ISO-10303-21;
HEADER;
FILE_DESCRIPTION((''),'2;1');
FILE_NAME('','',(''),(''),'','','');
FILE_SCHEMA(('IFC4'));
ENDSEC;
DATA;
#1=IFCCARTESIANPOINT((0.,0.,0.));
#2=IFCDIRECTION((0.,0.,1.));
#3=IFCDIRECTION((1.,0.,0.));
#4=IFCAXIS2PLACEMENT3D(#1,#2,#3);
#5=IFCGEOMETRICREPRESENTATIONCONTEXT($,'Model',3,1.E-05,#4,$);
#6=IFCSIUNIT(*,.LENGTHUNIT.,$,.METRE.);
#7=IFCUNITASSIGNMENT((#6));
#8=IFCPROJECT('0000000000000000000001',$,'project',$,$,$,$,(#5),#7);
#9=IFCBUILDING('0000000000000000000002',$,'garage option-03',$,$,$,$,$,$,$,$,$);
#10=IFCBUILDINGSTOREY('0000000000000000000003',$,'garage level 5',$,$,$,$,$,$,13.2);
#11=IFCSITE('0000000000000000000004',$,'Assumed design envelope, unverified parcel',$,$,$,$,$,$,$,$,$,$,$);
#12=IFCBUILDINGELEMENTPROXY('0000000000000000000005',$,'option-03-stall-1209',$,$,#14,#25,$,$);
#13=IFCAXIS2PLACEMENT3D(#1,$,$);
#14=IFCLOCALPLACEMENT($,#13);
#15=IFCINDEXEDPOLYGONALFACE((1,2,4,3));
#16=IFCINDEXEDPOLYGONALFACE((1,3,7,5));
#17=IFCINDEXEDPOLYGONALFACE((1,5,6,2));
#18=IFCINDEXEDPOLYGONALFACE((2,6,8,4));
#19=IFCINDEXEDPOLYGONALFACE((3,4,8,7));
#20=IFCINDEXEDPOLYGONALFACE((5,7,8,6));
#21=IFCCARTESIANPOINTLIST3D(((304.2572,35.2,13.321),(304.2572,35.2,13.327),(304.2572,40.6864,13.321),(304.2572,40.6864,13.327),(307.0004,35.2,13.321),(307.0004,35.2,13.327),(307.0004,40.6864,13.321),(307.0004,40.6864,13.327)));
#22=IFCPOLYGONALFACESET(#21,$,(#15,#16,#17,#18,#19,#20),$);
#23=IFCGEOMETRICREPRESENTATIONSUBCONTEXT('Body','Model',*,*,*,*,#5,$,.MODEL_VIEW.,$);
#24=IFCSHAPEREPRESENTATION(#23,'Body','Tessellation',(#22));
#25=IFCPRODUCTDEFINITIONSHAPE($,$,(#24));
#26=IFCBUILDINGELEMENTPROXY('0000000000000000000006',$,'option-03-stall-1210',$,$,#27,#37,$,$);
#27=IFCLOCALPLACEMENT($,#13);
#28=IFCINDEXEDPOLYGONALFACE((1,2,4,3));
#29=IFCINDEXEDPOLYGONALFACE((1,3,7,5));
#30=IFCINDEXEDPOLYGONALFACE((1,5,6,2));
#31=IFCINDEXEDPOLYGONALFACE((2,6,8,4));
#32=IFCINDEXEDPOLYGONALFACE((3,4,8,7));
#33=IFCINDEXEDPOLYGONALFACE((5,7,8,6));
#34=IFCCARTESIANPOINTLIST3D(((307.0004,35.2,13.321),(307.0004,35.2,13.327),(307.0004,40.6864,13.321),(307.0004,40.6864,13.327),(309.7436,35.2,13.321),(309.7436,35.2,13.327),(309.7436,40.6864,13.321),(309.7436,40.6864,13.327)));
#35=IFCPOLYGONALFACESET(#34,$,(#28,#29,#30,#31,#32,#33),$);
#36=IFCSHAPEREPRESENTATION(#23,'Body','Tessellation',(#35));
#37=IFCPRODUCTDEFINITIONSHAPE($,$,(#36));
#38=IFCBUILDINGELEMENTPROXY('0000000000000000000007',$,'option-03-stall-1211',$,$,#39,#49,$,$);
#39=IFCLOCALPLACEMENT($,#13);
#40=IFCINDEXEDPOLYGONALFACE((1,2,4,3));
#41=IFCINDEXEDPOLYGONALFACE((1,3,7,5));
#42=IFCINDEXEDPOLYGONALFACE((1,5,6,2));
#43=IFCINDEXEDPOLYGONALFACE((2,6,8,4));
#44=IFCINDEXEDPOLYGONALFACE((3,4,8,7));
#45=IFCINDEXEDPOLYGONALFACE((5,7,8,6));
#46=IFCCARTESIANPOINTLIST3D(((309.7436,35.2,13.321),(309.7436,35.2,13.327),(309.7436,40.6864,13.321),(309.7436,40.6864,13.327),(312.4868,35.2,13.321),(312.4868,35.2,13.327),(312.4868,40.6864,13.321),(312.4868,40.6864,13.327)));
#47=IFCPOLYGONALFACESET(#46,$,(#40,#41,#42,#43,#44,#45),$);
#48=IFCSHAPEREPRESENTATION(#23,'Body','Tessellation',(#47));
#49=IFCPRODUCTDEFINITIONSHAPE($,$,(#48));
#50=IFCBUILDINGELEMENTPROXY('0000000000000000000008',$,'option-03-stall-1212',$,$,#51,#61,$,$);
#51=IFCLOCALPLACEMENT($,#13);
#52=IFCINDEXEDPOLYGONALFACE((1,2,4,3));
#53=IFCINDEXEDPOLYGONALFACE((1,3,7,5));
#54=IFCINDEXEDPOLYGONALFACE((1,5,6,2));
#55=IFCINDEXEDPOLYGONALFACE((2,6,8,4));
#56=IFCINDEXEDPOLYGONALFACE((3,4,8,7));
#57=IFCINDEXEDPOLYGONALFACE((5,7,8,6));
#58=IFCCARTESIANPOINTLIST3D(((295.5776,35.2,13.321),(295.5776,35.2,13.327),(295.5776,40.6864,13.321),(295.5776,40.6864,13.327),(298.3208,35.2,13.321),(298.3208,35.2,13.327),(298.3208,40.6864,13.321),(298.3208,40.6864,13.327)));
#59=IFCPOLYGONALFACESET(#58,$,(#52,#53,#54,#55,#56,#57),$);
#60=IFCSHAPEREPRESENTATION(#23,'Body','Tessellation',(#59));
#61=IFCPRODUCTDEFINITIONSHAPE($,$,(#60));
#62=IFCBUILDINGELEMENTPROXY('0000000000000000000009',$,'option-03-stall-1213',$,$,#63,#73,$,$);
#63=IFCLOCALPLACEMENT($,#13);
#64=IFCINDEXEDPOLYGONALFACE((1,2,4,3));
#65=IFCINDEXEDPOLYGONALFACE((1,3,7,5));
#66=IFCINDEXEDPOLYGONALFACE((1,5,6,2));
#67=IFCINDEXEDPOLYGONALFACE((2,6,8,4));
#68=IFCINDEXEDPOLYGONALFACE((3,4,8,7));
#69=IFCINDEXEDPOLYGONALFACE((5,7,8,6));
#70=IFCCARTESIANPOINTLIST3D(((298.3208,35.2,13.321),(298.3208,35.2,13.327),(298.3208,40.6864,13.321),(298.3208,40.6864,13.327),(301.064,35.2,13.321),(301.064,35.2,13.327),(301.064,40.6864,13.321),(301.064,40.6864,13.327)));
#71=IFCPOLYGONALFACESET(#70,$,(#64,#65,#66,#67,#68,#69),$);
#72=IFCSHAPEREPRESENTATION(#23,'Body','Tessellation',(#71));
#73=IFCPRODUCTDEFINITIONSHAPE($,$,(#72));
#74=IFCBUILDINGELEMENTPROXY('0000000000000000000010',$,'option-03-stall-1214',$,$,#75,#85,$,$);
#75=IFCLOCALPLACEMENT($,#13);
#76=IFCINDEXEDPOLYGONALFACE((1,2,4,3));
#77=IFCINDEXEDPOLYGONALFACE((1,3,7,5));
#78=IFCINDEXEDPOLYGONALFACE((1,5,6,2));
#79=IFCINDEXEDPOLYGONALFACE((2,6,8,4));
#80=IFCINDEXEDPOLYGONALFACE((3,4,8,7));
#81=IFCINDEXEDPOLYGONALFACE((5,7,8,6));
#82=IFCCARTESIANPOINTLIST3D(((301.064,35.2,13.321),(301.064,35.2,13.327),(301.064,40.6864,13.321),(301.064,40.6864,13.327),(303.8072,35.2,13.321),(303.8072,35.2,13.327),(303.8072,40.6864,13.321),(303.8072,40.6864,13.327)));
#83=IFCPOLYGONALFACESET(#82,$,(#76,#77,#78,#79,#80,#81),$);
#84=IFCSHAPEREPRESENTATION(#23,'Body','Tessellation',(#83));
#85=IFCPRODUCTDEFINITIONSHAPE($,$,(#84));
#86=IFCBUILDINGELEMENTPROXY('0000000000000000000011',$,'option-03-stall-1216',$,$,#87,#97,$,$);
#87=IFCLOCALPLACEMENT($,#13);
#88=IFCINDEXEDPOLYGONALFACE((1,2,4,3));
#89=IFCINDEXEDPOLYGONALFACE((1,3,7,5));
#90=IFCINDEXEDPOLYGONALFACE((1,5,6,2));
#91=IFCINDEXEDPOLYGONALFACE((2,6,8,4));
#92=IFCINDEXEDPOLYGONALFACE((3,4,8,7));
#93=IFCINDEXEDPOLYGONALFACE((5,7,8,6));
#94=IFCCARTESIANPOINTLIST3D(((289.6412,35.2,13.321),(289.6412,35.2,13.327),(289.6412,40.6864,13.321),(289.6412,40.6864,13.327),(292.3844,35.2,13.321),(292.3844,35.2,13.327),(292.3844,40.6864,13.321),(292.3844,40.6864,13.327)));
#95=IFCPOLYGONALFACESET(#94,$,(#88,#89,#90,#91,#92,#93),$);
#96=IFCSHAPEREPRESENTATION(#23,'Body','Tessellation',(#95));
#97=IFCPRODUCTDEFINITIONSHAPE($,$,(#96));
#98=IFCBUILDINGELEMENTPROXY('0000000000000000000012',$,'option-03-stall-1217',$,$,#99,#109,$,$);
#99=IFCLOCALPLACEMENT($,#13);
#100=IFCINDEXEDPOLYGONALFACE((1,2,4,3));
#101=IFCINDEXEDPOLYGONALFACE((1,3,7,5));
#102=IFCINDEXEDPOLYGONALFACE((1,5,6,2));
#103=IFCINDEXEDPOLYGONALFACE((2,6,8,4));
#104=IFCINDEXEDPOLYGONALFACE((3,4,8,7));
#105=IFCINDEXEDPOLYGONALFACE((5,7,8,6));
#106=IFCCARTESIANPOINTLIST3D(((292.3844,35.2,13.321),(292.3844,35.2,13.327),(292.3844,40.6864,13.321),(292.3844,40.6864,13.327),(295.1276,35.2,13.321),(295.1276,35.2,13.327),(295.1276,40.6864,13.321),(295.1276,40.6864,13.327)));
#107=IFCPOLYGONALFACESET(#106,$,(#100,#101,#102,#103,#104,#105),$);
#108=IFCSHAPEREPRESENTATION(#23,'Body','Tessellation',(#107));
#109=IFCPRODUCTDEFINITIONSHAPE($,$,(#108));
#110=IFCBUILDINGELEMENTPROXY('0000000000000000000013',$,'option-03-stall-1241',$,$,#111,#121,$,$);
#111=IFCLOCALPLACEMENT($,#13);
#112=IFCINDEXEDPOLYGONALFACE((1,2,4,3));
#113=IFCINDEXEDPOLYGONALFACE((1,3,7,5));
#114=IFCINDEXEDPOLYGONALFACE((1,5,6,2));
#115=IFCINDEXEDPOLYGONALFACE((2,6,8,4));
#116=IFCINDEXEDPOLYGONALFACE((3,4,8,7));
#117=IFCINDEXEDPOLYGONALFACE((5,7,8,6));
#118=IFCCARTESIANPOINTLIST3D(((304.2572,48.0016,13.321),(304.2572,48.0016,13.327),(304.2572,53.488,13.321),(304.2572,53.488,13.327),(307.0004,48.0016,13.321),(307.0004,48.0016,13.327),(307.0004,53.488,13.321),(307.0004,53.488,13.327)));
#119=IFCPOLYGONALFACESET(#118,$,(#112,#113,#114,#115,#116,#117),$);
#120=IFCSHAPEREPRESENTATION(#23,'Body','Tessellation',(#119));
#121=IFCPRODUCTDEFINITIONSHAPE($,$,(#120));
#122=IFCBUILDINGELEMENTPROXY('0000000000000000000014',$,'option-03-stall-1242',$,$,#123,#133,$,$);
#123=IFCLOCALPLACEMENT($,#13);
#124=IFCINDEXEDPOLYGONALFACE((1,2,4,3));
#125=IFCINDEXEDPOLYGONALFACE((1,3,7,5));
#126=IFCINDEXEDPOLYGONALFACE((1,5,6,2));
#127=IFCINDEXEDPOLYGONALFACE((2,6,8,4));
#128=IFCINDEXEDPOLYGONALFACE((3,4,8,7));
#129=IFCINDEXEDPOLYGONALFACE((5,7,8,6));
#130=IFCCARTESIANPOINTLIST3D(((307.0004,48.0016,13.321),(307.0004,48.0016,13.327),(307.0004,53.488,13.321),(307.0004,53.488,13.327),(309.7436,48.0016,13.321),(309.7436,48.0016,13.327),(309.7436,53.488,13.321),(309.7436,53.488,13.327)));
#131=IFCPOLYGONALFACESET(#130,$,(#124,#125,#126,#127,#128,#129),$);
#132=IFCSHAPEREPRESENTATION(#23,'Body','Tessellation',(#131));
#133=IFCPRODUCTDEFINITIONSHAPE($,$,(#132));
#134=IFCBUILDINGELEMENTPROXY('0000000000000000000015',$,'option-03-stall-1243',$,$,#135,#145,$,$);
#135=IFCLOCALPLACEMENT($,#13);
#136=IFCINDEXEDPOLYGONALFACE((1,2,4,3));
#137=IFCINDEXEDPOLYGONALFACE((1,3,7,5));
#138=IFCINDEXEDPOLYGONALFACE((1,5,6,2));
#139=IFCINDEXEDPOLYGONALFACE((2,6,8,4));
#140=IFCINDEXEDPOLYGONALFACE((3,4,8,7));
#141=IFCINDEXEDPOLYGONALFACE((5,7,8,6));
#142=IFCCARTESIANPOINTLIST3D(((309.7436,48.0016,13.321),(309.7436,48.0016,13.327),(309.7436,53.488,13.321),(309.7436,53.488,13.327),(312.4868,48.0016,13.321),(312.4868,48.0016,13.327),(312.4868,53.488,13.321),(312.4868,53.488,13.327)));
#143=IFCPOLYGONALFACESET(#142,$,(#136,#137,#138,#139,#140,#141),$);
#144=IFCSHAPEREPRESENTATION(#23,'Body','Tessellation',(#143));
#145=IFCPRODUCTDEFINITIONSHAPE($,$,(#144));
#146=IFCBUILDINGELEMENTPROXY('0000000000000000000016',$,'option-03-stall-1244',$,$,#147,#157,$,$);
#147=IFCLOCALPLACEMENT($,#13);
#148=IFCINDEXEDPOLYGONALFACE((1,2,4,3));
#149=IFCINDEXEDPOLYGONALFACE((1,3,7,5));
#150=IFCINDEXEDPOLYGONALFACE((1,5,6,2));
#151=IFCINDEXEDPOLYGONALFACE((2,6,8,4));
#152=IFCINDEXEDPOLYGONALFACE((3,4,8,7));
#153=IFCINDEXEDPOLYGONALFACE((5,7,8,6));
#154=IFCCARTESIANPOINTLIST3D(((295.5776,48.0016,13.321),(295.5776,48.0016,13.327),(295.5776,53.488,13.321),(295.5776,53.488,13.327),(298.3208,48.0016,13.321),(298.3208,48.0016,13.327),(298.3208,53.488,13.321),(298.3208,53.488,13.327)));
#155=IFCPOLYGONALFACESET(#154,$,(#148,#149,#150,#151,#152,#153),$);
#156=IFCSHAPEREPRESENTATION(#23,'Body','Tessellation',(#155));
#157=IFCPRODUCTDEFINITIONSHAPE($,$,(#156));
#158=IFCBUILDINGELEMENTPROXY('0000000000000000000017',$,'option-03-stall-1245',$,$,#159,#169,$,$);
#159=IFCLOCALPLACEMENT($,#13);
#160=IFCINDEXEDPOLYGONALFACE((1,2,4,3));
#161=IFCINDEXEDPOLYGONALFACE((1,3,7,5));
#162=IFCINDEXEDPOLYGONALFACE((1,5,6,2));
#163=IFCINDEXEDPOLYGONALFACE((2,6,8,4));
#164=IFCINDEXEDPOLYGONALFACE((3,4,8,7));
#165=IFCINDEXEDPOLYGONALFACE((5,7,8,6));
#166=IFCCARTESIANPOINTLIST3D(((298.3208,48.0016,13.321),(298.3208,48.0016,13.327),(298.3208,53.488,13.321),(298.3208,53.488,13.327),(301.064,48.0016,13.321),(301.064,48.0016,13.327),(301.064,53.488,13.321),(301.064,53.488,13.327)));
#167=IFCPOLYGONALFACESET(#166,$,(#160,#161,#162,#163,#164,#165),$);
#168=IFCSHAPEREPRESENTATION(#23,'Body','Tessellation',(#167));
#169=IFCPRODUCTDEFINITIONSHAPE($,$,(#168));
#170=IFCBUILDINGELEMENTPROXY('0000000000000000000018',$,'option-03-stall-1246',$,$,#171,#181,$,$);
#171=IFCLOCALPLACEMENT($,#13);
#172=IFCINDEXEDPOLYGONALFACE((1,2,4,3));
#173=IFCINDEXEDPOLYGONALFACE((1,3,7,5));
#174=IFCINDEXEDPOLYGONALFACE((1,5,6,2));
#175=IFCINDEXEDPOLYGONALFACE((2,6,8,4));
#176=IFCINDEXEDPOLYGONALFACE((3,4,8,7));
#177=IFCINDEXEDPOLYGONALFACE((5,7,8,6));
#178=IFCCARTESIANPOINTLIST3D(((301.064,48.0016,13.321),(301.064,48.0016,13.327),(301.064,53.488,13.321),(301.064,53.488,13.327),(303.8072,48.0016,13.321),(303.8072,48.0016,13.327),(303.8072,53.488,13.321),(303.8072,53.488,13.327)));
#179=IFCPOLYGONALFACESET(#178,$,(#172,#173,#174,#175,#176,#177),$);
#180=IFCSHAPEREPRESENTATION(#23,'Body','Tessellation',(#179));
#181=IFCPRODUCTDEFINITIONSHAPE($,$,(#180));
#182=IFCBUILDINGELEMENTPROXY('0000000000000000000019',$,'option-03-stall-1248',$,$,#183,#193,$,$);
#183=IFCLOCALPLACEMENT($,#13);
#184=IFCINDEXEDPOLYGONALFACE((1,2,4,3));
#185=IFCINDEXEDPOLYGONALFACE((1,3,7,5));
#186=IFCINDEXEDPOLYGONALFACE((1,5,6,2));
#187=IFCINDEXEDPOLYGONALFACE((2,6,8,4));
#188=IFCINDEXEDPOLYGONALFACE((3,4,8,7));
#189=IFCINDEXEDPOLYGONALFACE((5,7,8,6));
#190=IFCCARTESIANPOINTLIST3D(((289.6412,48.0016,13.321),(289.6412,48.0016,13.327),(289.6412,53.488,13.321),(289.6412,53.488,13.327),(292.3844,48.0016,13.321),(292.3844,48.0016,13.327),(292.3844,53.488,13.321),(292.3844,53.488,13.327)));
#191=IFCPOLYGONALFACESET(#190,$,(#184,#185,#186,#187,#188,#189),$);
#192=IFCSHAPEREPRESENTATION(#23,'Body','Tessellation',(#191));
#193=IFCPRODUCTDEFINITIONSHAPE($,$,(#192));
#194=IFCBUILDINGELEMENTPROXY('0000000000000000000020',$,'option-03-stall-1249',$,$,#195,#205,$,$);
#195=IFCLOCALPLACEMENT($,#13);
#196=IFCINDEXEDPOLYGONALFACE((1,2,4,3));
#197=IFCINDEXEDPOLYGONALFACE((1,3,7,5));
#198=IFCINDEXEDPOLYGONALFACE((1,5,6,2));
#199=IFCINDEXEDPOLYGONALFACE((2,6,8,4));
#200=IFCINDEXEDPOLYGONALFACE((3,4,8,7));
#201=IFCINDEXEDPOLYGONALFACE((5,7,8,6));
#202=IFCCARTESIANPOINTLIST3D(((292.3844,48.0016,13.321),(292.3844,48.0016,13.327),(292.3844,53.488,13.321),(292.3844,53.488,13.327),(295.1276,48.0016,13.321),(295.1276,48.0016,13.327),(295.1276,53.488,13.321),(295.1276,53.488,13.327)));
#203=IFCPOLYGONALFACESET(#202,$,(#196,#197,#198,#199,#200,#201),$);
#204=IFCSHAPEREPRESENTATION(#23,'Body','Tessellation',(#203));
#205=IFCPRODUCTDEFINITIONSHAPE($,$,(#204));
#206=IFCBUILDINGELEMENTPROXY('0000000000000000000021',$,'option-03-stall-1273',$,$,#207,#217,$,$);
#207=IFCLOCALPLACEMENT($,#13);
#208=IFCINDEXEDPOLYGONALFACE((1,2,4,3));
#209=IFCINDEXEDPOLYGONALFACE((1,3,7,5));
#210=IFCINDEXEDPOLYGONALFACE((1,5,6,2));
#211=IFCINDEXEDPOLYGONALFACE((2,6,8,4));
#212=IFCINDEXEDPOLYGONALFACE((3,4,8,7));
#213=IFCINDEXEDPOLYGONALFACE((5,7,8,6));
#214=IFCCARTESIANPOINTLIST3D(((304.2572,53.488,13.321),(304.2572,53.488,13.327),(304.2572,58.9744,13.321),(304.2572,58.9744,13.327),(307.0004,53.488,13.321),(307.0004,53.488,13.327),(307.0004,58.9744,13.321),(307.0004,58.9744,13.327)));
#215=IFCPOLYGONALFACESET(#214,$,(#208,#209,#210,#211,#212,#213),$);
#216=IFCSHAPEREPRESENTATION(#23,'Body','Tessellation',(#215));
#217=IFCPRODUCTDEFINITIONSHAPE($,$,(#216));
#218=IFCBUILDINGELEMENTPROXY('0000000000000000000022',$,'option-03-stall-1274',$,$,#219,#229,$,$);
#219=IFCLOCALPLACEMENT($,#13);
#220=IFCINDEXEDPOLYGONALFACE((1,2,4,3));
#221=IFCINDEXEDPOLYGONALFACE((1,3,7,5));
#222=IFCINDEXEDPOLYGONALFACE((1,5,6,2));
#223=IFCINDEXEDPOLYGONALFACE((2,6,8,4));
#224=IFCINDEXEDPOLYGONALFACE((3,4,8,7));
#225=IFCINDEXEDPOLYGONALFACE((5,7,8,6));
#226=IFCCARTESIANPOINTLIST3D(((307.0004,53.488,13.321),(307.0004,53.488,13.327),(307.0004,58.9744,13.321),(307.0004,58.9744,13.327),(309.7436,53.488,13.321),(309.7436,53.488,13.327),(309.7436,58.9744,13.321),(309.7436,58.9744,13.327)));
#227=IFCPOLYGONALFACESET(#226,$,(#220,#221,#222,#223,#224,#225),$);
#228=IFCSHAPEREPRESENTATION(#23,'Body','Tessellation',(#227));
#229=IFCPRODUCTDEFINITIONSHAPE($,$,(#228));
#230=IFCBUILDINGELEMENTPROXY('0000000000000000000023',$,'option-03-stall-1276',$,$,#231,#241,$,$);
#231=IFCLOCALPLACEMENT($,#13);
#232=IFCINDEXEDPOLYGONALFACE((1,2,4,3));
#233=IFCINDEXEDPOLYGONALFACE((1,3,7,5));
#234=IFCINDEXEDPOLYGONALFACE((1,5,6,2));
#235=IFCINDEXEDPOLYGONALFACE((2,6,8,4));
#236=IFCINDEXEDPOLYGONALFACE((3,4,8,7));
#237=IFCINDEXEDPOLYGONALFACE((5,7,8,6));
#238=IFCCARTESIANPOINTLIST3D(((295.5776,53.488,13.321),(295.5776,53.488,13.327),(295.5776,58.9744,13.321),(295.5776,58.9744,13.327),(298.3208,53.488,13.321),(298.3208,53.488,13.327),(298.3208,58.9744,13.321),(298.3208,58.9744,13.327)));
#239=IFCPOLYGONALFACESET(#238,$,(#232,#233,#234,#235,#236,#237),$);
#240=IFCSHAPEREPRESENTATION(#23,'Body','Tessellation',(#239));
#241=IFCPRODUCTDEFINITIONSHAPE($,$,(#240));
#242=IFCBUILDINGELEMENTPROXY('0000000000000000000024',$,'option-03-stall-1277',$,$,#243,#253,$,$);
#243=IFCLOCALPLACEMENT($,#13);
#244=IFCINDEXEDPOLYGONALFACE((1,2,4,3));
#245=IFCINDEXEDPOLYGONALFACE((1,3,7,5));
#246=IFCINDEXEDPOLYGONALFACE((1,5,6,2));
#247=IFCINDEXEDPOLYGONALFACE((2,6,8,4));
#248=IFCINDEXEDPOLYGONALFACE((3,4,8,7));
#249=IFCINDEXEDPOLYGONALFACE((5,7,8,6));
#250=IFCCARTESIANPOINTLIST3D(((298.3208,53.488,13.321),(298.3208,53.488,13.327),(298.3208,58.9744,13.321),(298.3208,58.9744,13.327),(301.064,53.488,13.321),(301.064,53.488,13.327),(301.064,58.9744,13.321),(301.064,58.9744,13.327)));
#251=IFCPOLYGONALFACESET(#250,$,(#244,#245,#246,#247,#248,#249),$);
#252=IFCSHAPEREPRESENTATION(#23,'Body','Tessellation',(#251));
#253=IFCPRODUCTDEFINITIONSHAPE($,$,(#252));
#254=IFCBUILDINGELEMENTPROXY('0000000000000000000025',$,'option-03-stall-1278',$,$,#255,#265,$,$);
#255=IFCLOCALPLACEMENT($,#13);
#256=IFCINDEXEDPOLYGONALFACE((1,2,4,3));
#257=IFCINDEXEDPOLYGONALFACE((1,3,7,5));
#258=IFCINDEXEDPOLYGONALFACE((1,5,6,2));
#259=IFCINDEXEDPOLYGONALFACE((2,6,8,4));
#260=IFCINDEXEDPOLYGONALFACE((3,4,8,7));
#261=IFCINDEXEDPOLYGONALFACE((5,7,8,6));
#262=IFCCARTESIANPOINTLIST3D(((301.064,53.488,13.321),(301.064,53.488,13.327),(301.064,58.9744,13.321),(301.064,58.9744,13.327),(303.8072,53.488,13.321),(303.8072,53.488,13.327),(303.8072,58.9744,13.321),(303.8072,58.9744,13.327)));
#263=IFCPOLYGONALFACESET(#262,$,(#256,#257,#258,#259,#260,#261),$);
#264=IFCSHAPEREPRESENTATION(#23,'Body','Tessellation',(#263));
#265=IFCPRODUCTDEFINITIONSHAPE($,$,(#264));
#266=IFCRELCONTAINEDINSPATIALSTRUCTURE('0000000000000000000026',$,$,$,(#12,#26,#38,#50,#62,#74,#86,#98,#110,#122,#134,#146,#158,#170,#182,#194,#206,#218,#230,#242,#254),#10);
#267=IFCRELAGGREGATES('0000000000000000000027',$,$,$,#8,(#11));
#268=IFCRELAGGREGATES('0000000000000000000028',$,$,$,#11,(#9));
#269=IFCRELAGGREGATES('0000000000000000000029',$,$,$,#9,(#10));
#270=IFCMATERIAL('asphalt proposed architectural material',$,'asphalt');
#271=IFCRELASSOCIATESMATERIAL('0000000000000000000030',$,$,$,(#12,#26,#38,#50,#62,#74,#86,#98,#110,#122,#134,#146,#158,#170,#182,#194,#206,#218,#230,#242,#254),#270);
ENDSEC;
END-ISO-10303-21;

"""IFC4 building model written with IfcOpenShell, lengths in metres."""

from ifc_helpers import new_model, si_unit, frame, origin_with_axes, place, context, subcontext, project, spatial, rectangle, extrude, material, element, save


model = new_model("IFC4")

# Units and contexts
model_context = context("Model", 3, precision=1e-05, world=origin_with_axes())
body_context = subcontext(model_context, "Body", "Model", "MODEL_VIEW")
ifc_project = project(units=[si_unit("LENGTHUNIT", "METRE")], contexts=[model_context])

# Site, building, storey
site = spatial("IfcSite", under=ifc_project, Name="Assumed design envelope, unverified parcel")
building = spatial("IfcBuilding", under=site, Name="garage option-03")
storey = spatial("IfcBuildingStorey", under=building, Name="garage level 5", Elevation=13.2)

# Building element proxies
ifc_material = material(Name="asphalt proposed architectural material", Category="asphalt")
for number, where, z_axis, x_axis, name in (
    (1, (305.6288, 37.9432, 13.321), (0.0, 0.0, 1.0), (1.0, 0.0, 0.0), "option-03-stall-1209"),
    (2, (308.372, 37.9432, 13.321), (0.0, 0.0, 1.0), (1.0, 0.0, 0.0), "option-03-stall-1210"),
    (3, (311.1152, 37.9432, 13.321), (0.0, 0.0, 1.0), (1.0, 0.0, 0.0), "option-03-stall-1211"),
    (4, (296.9492, 37.9432, 13.321), (0.0, 0.0, 1.0), (1.0, 0.0, 0.0), "option-03-stall-1212"),
    (5, (299.6924, 37.9432, 13.321), (0.0, 0.0, 1.0), (1.0, 0.0, 0.0), "option-03-stall-1213"),
    (6, (302.4356, 37.9432, 13.321), (0.0, 0.0, 1.0), (1.0, 0.0, 0.0), "option-03-stall-1214"),
    (7, (291.0128, 37.9432, 13.321), (0.0, 0.0, 1.0), (1.0, 0.0, 0.0), "option-03-stall-1216"),
    (8, (293.756, 37.9432, 13.321), (0.0, 0.0, 1.0), (1.0, 0.0, 0.0), "option-03-stall-1217"),
    (9, (305.6288, 50.7448, 13.321), (0.0, 0.0, 1.0), (1.0, 0.0, 0.0), "option-03-stall-1241"),
    (10, (308.372, 50.7448, 13.321), (0.0, 0.0, 1.0), (1.0, 0.0, 0.0), "option-03-stall-1242"),
    (11, (311.1152, 50.7448, 13.321), (0.0, 0.0, 1.0), (1.0, 0.0, 0.0), "option-03-stall-1243"),
    (12, (296.9492, 50.7448, 13.321), (0.0, 0.0, 1.0), (1.0, 0.0, 0.0), "option-03-stall-1244"),
    (13, (299.6924, 50.7448, 13.321), (0.0, 0.0, 1.0), (1.0, 0.0, 0.0), "option-03-stall-1245"),
    (14, (302.4356, 50.7448, 13.321), (0.0, 0.0, 1.0), (1.0, 0.0, 0.0), "option-03-stall-1246"),
    (15, (291.0128, 50.7448, 13.321), (0.0, 0.0, 1.0), (1.0, 0.0, 0.0), "option-03-stall-1248"),
    (16, (293.756, 50.7448, 13.321), (0.0, 0.0, 1.0), (1.0, 0.0, 0.0), "option-03-stall-1249"),
):
    element("IfcBuildingElementProxy", number, at=place(None, frame(where, z_axis=z_axis, x_axis=x_axis)), inside=storey, material=ifc_material, Name=name, context=body_context, shape_type="SweptSolid", body=[
        extrude(rectangle(XDim=2.7432, YDim=5.4864), origin_with_axes(), (0.0, 0.0, 1.0), 0.006),
    ])
for number, where, z_axis, x_axis, name in (
    (17, (305.6288, 56.2312, 13.321), (0.0, 0.0, 1.0), (1.0, 0.0, 0.0), "option-03-stall-1273"),
    (18, (308.372, 56.2312, 13.321), (0.0, 0.0, 1.0), (1.0, 0.0, 0.0), "option-03-stall-1274"),
    (19, (296.9492, 56.2312, 13.321), (0.0, 0.0, 1.0), (1.0, 0.0, 0.0), "option-03-stall-1276"),
    (20, (299.6924, 56.2312, 13.321), (0.0, 0.0, 1.0), (1.0, 0.0, 0.0), "option-03-stall-1277"),
    (21, (302.4356, 56.2312, 13.321), (0.0, 0.0, 1.0), (1.0, 0.0, 0.0), "option-03-stall-1278"),
):
    element("IfcBuildingElementProxy", number, at=place(None, frame(where, z_axis=z_axis, x_axis=x_axis)), inside=storey, material=ifc_material, Name=name, context=body_context, shape_type="SweptSolid", body=[
        extrude(rectangle(XDim=2.7432, YDim=5.4864), origin_with_axes(), (0.0, 0.0, 1.0), 0.006),
    ])

save(model, "model.ifc")
